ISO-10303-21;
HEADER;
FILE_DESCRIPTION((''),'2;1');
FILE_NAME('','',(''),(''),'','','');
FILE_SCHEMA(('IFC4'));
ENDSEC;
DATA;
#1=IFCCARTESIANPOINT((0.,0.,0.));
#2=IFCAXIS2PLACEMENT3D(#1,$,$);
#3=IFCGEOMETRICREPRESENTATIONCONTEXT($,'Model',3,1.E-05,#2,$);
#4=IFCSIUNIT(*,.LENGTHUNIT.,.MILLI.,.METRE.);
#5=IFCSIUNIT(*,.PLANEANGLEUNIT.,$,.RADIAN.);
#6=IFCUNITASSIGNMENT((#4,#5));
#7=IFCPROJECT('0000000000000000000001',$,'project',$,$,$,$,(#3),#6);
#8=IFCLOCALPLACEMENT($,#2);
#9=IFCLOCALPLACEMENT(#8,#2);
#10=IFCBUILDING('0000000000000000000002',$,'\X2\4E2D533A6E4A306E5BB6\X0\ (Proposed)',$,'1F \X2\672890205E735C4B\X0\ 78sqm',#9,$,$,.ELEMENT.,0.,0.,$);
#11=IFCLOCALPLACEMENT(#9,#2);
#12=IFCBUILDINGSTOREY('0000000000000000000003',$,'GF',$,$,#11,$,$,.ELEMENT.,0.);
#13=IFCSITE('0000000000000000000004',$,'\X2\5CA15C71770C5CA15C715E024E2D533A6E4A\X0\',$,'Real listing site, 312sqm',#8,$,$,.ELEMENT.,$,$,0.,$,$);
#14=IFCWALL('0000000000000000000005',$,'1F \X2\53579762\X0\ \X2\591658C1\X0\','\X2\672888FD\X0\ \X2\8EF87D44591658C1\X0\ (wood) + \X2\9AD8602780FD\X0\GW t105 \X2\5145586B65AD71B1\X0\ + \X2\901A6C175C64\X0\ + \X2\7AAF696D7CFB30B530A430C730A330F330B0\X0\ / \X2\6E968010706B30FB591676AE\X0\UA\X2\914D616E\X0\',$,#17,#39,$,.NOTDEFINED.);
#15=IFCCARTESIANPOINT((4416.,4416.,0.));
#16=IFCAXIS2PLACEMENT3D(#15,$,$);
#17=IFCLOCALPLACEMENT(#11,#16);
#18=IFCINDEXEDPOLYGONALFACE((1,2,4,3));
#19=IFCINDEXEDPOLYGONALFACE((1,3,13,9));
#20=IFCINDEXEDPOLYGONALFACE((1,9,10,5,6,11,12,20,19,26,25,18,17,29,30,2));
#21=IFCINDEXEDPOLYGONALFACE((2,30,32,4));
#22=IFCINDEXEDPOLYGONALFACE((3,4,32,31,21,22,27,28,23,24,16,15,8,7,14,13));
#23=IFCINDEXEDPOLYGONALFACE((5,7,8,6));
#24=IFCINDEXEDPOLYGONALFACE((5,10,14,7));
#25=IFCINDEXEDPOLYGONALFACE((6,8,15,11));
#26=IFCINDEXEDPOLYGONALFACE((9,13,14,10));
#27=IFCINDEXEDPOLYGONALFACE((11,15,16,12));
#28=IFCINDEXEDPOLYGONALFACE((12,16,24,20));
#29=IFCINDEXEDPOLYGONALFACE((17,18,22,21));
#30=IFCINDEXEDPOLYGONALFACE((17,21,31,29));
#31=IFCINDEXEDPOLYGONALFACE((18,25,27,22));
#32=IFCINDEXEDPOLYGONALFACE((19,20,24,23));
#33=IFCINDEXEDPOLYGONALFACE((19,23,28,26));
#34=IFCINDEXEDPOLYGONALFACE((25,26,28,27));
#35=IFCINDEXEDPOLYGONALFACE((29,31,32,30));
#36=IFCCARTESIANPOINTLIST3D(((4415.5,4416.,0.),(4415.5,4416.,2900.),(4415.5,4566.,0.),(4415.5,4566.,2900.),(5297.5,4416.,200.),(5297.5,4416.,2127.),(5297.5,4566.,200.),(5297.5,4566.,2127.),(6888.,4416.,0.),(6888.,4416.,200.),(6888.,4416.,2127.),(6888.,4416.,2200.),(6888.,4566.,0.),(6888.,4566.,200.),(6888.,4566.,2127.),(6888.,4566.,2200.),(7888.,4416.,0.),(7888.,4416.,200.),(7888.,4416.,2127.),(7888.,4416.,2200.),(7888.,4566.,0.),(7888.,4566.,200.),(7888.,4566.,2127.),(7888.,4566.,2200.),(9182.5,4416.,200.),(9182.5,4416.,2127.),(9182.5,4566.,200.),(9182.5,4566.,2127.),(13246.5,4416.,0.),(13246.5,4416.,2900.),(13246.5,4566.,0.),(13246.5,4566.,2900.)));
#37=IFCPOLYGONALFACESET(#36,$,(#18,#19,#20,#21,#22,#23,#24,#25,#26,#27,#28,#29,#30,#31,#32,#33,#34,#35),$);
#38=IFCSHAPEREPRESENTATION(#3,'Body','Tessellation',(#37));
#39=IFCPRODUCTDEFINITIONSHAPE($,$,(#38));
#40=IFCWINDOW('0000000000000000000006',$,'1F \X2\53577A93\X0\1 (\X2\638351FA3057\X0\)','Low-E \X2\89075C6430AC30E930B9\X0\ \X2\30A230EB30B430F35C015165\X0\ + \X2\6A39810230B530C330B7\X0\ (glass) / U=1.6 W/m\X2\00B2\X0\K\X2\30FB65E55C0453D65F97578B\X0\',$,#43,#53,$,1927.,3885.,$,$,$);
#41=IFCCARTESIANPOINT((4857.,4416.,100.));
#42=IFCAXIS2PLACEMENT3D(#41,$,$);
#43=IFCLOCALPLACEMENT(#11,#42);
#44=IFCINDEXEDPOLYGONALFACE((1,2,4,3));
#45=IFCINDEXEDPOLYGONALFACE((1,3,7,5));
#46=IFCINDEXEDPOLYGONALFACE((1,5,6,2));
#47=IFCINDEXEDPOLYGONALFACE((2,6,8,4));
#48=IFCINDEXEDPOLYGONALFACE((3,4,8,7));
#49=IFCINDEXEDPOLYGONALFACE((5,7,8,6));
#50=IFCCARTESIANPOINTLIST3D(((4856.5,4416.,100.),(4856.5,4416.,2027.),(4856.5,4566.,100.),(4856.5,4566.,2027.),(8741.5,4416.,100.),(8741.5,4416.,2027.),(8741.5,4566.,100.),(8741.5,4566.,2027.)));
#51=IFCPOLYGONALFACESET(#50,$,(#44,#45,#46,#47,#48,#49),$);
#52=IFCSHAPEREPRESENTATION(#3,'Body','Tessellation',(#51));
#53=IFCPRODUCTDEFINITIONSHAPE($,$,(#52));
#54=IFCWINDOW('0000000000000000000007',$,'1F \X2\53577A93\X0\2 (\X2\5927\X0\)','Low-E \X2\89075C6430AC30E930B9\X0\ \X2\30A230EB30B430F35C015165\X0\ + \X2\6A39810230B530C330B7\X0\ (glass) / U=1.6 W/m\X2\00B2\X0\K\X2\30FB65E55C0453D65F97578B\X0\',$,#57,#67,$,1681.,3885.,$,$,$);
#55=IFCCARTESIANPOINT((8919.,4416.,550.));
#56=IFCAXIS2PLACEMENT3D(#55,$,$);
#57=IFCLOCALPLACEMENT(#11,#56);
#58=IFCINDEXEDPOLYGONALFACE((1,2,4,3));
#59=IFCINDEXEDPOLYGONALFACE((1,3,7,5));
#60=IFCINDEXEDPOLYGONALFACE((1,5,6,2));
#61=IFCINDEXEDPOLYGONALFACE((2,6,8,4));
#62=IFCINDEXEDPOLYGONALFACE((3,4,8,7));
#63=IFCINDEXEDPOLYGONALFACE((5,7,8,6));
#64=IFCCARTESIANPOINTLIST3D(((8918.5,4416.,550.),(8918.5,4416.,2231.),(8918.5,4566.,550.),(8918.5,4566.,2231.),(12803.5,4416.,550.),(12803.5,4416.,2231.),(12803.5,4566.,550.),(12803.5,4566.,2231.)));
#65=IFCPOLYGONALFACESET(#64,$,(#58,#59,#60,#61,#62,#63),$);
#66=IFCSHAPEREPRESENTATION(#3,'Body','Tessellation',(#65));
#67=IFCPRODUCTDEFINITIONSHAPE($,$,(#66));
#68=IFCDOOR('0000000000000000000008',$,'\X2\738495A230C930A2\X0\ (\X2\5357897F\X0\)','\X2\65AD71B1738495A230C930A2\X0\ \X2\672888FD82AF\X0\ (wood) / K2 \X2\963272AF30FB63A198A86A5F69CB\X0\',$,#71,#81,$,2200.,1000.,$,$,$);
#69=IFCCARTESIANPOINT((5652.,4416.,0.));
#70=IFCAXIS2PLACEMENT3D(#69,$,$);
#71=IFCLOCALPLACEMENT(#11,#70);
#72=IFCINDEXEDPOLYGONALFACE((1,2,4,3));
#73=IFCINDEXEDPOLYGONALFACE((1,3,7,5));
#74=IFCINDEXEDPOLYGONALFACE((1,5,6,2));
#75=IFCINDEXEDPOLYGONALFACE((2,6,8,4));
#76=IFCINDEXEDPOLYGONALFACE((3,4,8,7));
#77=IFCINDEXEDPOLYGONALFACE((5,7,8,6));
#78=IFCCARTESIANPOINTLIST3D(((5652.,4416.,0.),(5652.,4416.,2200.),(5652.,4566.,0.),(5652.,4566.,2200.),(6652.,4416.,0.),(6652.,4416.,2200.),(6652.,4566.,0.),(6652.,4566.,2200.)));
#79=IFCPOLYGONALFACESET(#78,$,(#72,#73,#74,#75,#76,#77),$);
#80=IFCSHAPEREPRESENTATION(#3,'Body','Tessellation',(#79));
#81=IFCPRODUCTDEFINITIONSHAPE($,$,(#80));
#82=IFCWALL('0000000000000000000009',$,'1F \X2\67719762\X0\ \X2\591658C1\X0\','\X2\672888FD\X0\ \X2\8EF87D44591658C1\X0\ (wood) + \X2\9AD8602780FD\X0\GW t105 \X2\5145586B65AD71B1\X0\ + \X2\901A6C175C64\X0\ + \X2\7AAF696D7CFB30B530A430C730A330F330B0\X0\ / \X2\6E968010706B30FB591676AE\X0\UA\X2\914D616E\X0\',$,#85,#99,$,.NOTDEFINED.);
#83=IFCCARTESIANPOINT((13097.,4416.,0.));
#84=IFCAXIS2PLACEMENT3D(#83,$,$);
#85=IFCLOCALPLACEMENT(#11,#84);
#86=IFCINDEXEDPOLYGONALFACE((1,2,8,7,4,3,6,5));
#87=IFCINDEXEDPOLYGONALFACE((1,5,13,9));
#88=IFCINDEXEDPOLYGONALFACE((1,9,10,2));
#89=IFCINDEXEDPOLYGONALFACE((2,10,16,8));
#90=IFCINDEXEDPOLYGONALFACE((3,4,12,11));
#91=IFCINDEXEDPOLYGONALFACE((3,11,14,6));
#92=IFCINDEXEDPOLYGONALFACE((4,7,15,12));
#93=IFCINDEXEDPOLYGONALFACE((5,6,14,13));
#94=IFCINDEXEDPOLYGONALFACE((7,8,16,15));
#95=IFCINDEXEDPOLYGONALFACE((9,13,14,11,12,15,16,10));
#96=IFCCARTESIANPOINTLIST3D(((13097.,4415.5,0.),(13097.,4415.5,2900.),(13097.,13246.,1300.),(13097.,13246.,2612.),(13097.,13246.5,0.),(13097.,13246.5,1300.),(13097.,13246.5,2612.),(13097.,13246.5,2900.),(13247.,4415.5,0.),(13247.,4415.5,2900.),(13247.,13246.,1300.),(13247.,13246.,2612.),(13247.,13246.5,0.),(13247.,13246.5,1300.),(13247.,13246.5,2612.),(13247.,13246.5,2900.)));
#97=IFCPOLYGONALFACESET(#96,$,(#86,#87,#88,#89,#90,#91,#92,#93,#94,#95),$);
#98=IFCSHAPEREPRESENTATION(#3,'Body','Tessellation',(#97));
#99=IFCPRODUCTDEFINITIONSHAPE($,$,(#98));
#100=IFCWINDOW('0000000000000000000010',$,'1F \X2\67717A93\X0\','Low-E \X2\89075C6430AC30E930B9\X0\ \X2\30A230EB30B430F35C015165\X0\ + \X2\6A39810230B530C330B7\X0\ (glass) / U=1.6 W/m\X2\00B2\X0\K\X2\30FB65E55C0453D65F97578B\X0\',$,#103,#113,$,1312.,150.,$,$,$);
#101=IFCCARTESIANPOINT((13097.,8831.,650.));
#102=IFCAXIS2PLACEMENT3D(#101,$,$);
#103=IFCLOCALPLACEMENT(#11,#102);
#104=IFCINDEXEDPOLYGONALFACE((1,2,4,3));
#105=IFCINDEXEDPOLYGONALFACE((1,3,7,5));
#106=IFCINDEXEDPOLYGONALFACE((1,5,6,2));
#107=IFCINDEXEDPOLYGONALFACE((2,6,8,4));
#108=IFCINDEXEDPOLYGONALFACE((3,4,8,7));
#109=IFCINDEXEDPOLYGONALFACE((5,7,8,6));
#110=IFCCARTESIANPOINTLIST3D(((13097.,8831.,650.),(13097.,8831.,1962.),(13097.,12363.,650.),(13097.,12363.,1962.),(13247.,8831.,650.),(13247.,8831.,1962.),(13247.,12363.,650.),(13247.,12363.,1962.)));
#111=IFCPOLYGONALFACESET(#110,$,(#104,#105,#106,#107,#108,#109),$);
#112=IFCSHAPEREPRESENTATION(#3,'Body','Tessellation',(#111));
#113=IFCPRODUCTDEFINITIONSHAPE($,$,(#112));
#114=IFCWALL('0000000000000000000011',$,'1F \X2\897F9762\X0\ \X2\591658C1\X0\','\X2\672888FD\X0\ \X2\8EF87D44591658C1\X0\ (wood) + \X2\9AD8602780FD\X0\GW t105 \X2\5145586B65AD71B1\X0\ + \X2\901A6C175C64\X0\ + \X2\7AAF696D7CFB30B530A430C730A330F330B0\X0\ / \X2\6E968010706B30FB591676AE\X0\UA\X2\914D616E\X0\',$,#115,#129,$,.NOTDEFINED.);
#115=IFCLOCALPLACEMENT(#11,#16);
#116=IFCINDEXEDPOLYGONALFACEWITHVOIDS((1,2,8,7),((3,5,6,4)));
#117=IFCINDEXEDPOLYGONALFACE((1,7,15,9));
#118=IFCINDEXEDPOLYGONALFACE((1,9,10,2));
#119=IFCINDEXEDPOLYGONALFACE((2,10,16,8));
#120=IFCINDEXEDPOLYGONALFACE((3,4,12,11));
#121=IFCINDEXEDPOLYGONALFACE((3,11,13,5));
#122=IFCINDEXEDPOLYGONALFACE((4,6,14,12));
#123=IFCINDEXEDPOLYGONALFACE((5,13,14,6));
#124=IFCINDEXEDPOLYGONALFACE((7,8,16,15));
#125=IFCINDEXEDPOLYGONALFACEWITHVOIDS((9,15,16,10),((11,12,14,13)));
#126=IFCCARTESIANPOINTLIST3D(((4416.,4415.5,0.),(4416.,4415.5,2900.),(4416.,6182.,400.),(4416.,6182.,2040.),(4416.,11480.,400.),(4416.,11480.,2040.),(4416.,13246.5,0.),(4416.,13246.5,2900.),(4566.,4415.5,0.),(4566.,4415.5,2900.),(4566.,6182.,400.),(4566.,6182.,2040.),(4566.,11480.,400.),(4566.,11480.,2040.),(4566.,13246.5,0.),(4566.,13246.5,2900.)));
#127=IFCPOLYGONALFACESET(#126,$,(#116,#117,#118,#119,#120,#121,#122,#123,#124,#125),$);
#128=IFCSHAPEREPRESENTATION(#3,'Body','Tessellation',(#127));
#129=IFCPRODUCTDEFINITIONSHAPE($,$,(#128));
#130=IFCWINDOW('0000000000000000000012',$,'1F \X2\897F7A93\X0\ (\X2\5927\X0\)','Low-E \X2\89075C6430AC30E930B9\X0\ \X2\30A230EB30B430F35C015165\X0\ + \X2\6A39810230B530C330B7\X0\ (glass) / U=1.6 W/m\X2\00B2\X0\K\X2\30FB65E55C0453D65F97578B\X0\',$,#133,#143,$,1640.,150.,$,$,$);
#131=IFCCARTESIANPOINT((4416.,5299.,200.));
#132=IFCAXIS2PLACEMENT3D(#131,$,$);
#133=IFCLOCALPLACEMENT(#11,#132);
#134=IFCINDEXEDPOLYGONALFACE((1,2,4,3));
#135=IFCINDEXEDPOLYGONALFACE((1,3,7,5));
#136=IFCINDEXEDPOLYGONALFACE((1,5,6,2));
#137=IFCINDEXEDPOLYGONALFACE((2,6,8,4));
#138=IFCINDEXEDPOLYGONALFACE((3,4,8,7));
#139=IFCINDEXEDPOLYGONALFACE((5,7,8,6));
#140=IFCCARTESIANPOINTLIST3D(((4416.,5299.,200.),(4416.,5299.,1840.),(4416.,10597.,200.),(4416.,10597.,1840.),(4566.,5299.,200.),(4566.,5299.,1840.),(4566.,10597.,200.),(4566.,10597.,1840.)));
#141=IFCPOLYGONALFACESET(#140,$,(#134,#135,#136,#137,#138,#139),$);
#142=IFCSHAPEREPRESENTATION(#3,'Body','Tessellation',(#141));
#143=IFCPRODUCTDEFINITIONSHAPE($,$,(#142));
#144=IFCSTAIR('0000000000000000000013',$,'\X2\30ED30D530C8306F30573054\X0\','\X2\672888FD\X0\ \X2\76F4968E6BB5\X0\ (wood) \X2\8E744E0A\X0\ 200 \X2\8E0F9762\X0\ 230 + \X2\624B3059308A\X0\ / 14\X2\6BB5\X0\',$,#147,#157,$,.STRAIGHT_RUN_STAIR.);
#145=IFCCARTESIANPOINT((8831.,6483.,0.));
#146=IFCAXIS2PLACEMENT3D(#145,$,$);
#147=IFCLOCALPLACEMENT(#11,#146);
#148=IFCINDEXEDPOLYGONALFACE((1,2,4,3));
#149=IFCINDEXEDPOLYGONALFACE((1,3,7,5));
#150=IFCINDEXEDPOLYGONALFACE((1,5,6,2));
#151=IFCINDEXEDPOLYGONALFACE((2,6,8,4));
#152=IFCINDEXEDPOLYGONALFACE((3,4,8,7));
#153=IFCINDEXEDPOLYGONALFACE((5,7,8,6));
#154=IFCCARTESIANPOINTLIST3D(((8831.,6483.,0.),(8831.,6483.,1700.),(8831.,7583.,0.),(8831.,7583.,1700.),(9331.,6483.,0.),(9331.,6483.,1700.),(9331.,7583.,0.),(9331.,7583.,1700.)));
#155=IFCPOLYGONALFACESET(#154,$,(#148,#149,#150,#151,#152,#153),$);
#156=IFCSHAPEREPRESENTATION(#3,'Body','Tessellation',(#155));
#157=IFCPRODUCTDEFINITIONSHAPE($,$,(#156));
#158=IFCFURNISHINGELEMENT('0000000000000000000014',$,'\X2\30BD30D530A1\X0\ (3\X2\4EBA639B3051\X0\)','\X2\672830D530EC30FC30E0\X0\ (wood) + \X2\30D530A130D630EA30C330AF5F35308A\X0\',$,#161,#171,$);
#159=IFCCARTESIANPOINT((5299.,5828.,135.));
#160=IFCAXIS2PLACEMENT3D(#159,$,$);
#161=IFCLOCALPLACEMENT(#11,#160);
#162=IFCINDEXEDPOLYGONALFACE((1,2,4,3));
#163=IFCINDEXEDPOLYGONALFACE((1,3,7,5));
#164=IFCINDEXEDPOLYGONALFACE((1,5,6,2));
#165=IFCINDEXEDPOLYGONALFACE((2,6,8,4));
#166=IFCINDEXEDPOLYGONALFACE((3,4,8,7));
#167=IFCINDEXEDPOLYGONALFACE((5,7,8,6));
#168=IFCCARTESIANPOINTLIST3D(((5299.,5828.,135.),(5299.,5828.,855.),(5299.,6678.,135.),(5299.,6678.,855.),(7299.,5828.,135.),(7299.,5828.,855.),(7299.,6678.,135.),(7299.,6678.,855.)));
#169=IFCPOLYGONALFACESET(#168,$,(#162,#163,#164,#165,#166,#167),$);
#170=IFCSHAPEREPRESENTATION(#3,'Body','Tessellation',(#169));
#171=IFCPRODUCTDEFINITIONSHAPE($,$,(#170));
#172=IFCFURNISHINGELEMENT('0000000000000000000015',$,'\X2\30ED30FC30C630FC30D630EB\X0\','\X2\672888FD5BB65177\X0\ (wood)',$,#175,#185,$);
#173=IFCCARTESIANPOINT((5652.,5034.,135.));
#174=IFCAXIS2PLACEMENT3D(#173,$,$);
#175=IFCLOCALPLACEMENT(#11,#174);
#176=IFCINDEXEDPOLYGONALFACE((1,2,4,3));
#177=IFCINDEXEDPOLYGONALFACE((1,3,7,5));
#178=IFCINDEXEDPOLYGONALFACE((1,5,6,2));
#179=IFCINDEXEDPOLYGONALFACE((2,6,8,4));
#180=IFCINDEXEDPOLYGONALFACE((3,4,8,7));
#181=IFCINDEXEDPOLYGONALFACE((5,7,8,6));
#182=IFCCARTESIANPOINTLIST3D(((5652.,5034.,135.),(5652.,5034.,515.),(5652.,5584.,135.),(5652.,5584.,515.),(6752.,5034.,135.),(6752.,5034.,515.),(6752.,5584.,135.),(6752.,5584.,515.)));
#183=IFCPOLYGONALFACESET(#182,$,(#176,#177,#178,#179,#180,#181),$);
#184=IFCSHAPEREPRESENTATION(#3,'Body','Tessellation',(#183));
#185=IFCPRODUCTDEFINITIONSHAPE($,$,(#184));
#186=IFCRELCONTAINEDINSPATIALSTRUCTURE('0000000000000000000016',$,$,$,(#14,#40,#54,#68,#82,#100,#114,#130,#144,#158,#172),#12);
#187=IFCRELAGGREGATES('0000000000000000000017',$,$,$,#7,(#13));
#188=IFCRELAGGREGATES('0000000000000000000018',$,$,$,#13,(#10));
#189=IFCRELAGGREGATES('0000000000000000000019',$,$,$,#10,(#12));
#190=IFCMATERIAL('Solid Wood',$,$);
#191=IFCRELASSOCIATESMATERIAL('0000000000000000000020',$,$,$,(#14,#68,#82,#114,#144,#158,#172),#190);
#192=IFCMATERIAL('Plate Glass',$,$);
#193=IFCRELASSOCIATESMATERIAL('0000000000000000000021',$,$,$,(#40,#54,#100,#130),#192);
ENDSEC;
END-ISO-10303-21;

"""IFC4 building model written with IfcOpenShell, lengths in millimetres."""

from ifc_helpers import new_model, si_unit, frame, frame_2d, origin, place, context, project, spatial, rectangle, extrude, material, element, fill, save


model = new_model("IFC4")

# Units and contexts
model_context = context("Model", 3, precision=1e-05, world=origin())
ifc_project = project(units=[si_unit("LENGTHUNIT", "METRE", prefix="MILLI"), si_unit("PLANEANGLEUNIT", "RADIAN")], contexts=[model_context])

# Site, building, storey
site_placement = place(None, origin())
site = spatial("IfcSite", under=ifc_project, at=site_placement, Name="岡山県岡山市中区湊", ObjectType="Real listing site, 312sqm", CompositionType="ELEMENT", RefElevation=0.0)
building_placement = place(site_placement, origin())
building = spatial("IfcBuilding", under=site, at=building_placement, Name="中区湊の家 (Proposed)", ObjectType="1F 木造平屋 78sqm", CompositionType="ELEMENT", ElevationOfRefHeight=0.0, ElevationOfTerrain=0.0)
storey_placement = place(building_placement, origin())
storey = spatial("IfcBuildingStorey", under=building, at=storey_placement, Name="GF", CompositionType="ELEMENT", Elevation=0.0)

# Shared definitions
ifc_material_1 = material(Name="Solid Wood")

# Wall, openings, windows, door
wall_1_placement = place(storey_placement, frame((4416.0, 4416.0, 0.0)))
wall_1 = element("IfcWall", 1, at=wall_1_placement, inside=storey, material=ifc_material_1, Name="1F 南面 外壁", Description="木製 軸組外壁 (wood) + 高性能GW t105 充填断熱 + 通気層 + 窯業系サイディング / 準耐火・外皮UA配慮", PredefinedType="NOTDEFINED", context=model_context, shape_type="SweptSolid", body=[
    extrude(rectangle(XDim=8831.0, YDim=150.0, at=frame_2d((4415.0, 75.0))), frame((4416.0, 4416.0, 0.0)), (0.0, 0.0, 1.0), 2900.0),
])
opening_1_placement = place(storey_placement, frame((4857.0, 4416.0, 100.0)))
opening_1 = element("IfcOpeningElement", 2, at=opening_1_placement, cuts=wall_1, PredefinedType="NOTDEFINED", context=model_context, shape_type="SweptSolid", body=[
    extrude(rectangle(XDim=3885.0, YDim=150.0, at=frame_2d((1942.0, 75.0))), frame((4857.0, 4416.0, 100.0)), (0.0, 0.0, 1.0), 1927.0),
])
opening_2_placement = place(storey_placement, frame((8919.0, 4416.0, 550.0)))
opening_2 = element("IfcOpeningElement", 3, at=opening_2_placement, cuts=wall_1, PredefinedType="NOTDEFINED", context=model_context, shape_type="SweptSolid", body=[
    extrude(rectangle(XDim=3885.0, YDim=150.0, at=frame_2d((1942.0, 75.0))), frame((8919.0, 4416.0, 550.0)), (0.0, 0.0, 1.0), 1681.0),
])
opening_3_placement = place(storey_placement, frame((5652.0, 4416.0, 0.0)))
opening_3 = element("IfcOpeningElement", 4, at=opening_3_placement, cuts=wall_1, PredefinedType="NOTDEFINED", context=model_context, shape_type="SweptSolid", body=[
    extrude(rectangle(XDim=1000.0, YDim=150.0, at=frame_2d((500.0, 75.0))), frame((5652.0, 4416.0, 0.0)), (0.0, 0.0, 1.0), 2200.0),
])
ifc_material_2 = material(Name="Plate Glass")
window_1_placement = place(storey_placement, frame((4857.0, 4416.0, 100.0)))
window_1 = element("IfcWindow", 5, at=window_1_placement, inside=storey, material=ifc_material_2, Name="1F 南窓1 (掃出し)", Description="Low-E 複層ガラス アルゴン封入 + 樹脂サッシ (glass) / U=1.6 W/m²K・日射取得型", OverallHeight=1927.0, OverallWidth=3885.0, context=model_context, shape_type="SweptSolid", body=[
    extrude(rectangle(XDim=3885.0, YDim=150.0, at=frame_2d((1942.0, 75.0))), frame((4857.0, 4416.0, 100.0)), (0.0, 0.0, 1.0), 1927.0),
])
fill(opening_1, window_1)
window_2_placement = place(storey_placement, frame((8919.0, 4416.0, 550.0)))
window_2 = element("IfcWindow", 6, at=window_2_placement, inside=storey, material=ifc_material_2, Name="1F 南窓2 (大)", Description="Low-E 複層ガラス アルゴン封入 + 樹脂サッシ (glass) / U=1.6 W/m²K・日射取得型", OverallHeight=1681.0, OverallWidth=3885.0, context=model_context, shape_type="SweptSolid", body=[
    extrude(rectangle(XDim=3885.0, YDim=150.0, at=frame_2d((1942.0, 75.0))), frame((8919.0, 4416.0, 550.0)), (0.0, 0.0, 1.0), 1681.0),
])
fill(opening_2, window_2)
door_placement = place(storey_placement, frame((5652.0, 4416.0, 0.0)))
door = element("IfcDoor", 7, at=door_placement, inside=storey, material=ifc_material_1, Name="玄関ドア (南西)", Description="断熱玄関ドア 木製芯 (wood) / K2 防犯・採風機構", OverallHeight=2200.0, OverallWidth=1000.0, context=model_context, shape_type="SweptSolid", body=[
    extrude(rectangle(XDim=1000.0, YDim=150.0, at=frame_2d((500.0, 75.0))), frame((5652.0, 4416.0, 0.0)), (0.0, 0.0, 1.0), 2200.0),
])
fill(opening_3, door)

# Walls, openings, windows
wall_2_placement = place(storey_placement, frame((13097.0, 4416.0, 0.0)))
wall_2 = element("IfcWall", 8, at=wall_2_placement, inside=storey, material=ifc_material_1, Name="1F 東面 外壁", Description="木製 軸組外壁 (wood) + 高性能GW t105 充填断熱 + 通気層 + 窯業系サイディング / 準耐火・外皮UA配慮", PredefinedType="NOTDEFINED", context=model_context, shape_type="SweptSolid", body=[
    extrude(rectangle(XDim=150.0, YDim=8831.0, at=frame_2d((75.0, 4415.0))), frame((13097.0, 4416.0, 0.0)), (0.0, 0.0, 1.0), 2900.0),
])
opening_4_placement = place(storey_placement, frame((13097.0, 8831.0, 650.0)))
opening_4 = element("IfcOpeningElement", 9, at=opening_4_placement, cuts=wall_2, PredefinedType="NOTDEFINED", context=model_context, shape_type="SweptSolid", body=[
    extrude(rectangle(XDim=150.0, YDim=3532.0, at=frame_2d((75.0, 1766.0))), frame((13097.0, 8831.0, 650.0)), (0.0, 0.0, 1.0), 1312.0),
])
window_3_placement = place(storey_placement, frame((13097.0, 8831.0, 650.0)))
window_3 = element("IfcWindow", 10, at=window_3_placement, inside=storey, material=ifc_material_2, Name="1F 東窓", Description="Low-E 複層ガラス アルゴン封入 + 樹脂サッシ (glass) / U=1.6 W/m²K・日射取得型", OverallHeight=1312.0, OverallWidth=150.0, context=model_context, shape_type="SweptSolid", body=[
    extrude(rectangle(XDim=150.0, YDim=3532.0, at=frame_2d((75.0, 1766.0))), frame((13097.0, 8831.0, 650.0)), (0.0, 0.0, 1.0), 1312.0),
])
fill(opening_4, window_3)
wall_3_placement = place(storey_placement, frame((4416.0, 4416.0, 0.0)))
wall_3 = element("IfcWall", 11, at=wall_3_placement, inside=storey, material=ifc_material_1, Name="1F 西面 外壁", Description="木製 軸組外壁 (wood) + 高性能GW t105 充填断熱 + 通気層 + 窯業系サイディング / 準耐火・外皮UA配慮", PredefinedType="NOTDEFINED", context=model_context, shape_type="SweptSolid", body=[
    extrude(rectangle(XDim=150.0, YDim=8831.0, at=frame_2d((75.0, 4415.0))), frame((4416.0, 4416.0, 0.0)), (0.0, 0.0, 1.0), 2900.0),
])
opening_5_placement = place(storey_placement, frame((4416.0, 5299.0, 200.0)))
opening_5 = element("IfcOpeningElement", 12, at=opening_5_placement, cuts=wall_3, PredefinedType="NOTDEFINED", context=model_context, shape_type="SweptSolid", body=[
    extrude(rectangle(XDim=150.0, YDim=5298.0, at=frame_2d((75.0, 2649.0))), frame((4416.0, 5299.0, 200.0)), (0.0, 0.0, 1.0), 1640.0),
])
window_4_placement = place(storey_placement, frame((4416.0, 5299.0, 200.0)))
window_4 = element("IfcWindow", 13, at=window_4_placement, inside=storey, material=ifc_material_2, Name="1F 西窓 (大)", Description="Low-E 複層ガラス アルゴン封入 + 樹脂サッシ (glass) / U=1.6 W/m²K・日射取得型", OverallHeight=1640.0, OverallWidth=150.0, context=model_context, shape_type="SweptSolid", body=[
    extrude(rectangle(XDim=150.0, YDim=5298.0, at=frame_2d((75.0, 2649.0))), frame((4416.0, 5299.0, 200.0)), (0.0, 0.0, 1.0), 1640.0),
])
fill(opening_5, window_4)

# Stair
stair_placement = place(storey_placement, frame((8831.0, 6483.0, 0.0)))
element("IfcStair", 14, at=stair_placement, inside=storey, material=ifc_material_1, Name="ロフトはしご", Description="木製 直階段 (wood) 蹴上 200 踏面 230 + 手すり / 14段", PredefinedType="STRAIGHT_RUN_STAIR", context=model_context, shape_type="SweptSolid", body=[
    extrude(rectangle(XDim=500.0, YDim=1100.0, at=frame_2d((250.0, 550.0))), frame((8831.0, 6483.0, 0.0)), (0.0, 0.0, 1.0), 1700.0),
])

# Furnishing elements
furnishing_1_placement = place(storey_placement, frame((5299.0, 5828.0, 135.0)))
element("IfcFurnishingElement", 15, at=furnishing_1_placement, inside=storey, material=ifc_material_1, Name="ソファ (3人掛け)", Description="木フレーム (wood) + ファブリック張り", context=model_context, shape_type="SweptSolid", body=[
    extrude(rectangle(XDim=2000.0, YDim=850.0, at=frame_2d((1000.0, 425.0))), frame((5299.0, 5828.0, 135.0)), (0.0, 0.0, 1.0), 720.0),
])
furnishing_2_placement = place(storey_placement, frame((5652.0, 5034.0, 135.0)))
element("IfcFurnishingElement", 16, at=furnishing_2_placement, inside=storey, material=ifc_material_1, Name="ローテーブル", Description="木製家具 (wood)", context=model_context, shape_type="SweptSolid", body=[
    extrude(rectangle(XDim=1100.0, YDim=550.0, at=frame_2d((550.0, 275.0))), frame((5652.0, 5034.0, 135.0)), (0.0, 0.0, 1.0), 380.0),
])

save(model, "model.ifc")
